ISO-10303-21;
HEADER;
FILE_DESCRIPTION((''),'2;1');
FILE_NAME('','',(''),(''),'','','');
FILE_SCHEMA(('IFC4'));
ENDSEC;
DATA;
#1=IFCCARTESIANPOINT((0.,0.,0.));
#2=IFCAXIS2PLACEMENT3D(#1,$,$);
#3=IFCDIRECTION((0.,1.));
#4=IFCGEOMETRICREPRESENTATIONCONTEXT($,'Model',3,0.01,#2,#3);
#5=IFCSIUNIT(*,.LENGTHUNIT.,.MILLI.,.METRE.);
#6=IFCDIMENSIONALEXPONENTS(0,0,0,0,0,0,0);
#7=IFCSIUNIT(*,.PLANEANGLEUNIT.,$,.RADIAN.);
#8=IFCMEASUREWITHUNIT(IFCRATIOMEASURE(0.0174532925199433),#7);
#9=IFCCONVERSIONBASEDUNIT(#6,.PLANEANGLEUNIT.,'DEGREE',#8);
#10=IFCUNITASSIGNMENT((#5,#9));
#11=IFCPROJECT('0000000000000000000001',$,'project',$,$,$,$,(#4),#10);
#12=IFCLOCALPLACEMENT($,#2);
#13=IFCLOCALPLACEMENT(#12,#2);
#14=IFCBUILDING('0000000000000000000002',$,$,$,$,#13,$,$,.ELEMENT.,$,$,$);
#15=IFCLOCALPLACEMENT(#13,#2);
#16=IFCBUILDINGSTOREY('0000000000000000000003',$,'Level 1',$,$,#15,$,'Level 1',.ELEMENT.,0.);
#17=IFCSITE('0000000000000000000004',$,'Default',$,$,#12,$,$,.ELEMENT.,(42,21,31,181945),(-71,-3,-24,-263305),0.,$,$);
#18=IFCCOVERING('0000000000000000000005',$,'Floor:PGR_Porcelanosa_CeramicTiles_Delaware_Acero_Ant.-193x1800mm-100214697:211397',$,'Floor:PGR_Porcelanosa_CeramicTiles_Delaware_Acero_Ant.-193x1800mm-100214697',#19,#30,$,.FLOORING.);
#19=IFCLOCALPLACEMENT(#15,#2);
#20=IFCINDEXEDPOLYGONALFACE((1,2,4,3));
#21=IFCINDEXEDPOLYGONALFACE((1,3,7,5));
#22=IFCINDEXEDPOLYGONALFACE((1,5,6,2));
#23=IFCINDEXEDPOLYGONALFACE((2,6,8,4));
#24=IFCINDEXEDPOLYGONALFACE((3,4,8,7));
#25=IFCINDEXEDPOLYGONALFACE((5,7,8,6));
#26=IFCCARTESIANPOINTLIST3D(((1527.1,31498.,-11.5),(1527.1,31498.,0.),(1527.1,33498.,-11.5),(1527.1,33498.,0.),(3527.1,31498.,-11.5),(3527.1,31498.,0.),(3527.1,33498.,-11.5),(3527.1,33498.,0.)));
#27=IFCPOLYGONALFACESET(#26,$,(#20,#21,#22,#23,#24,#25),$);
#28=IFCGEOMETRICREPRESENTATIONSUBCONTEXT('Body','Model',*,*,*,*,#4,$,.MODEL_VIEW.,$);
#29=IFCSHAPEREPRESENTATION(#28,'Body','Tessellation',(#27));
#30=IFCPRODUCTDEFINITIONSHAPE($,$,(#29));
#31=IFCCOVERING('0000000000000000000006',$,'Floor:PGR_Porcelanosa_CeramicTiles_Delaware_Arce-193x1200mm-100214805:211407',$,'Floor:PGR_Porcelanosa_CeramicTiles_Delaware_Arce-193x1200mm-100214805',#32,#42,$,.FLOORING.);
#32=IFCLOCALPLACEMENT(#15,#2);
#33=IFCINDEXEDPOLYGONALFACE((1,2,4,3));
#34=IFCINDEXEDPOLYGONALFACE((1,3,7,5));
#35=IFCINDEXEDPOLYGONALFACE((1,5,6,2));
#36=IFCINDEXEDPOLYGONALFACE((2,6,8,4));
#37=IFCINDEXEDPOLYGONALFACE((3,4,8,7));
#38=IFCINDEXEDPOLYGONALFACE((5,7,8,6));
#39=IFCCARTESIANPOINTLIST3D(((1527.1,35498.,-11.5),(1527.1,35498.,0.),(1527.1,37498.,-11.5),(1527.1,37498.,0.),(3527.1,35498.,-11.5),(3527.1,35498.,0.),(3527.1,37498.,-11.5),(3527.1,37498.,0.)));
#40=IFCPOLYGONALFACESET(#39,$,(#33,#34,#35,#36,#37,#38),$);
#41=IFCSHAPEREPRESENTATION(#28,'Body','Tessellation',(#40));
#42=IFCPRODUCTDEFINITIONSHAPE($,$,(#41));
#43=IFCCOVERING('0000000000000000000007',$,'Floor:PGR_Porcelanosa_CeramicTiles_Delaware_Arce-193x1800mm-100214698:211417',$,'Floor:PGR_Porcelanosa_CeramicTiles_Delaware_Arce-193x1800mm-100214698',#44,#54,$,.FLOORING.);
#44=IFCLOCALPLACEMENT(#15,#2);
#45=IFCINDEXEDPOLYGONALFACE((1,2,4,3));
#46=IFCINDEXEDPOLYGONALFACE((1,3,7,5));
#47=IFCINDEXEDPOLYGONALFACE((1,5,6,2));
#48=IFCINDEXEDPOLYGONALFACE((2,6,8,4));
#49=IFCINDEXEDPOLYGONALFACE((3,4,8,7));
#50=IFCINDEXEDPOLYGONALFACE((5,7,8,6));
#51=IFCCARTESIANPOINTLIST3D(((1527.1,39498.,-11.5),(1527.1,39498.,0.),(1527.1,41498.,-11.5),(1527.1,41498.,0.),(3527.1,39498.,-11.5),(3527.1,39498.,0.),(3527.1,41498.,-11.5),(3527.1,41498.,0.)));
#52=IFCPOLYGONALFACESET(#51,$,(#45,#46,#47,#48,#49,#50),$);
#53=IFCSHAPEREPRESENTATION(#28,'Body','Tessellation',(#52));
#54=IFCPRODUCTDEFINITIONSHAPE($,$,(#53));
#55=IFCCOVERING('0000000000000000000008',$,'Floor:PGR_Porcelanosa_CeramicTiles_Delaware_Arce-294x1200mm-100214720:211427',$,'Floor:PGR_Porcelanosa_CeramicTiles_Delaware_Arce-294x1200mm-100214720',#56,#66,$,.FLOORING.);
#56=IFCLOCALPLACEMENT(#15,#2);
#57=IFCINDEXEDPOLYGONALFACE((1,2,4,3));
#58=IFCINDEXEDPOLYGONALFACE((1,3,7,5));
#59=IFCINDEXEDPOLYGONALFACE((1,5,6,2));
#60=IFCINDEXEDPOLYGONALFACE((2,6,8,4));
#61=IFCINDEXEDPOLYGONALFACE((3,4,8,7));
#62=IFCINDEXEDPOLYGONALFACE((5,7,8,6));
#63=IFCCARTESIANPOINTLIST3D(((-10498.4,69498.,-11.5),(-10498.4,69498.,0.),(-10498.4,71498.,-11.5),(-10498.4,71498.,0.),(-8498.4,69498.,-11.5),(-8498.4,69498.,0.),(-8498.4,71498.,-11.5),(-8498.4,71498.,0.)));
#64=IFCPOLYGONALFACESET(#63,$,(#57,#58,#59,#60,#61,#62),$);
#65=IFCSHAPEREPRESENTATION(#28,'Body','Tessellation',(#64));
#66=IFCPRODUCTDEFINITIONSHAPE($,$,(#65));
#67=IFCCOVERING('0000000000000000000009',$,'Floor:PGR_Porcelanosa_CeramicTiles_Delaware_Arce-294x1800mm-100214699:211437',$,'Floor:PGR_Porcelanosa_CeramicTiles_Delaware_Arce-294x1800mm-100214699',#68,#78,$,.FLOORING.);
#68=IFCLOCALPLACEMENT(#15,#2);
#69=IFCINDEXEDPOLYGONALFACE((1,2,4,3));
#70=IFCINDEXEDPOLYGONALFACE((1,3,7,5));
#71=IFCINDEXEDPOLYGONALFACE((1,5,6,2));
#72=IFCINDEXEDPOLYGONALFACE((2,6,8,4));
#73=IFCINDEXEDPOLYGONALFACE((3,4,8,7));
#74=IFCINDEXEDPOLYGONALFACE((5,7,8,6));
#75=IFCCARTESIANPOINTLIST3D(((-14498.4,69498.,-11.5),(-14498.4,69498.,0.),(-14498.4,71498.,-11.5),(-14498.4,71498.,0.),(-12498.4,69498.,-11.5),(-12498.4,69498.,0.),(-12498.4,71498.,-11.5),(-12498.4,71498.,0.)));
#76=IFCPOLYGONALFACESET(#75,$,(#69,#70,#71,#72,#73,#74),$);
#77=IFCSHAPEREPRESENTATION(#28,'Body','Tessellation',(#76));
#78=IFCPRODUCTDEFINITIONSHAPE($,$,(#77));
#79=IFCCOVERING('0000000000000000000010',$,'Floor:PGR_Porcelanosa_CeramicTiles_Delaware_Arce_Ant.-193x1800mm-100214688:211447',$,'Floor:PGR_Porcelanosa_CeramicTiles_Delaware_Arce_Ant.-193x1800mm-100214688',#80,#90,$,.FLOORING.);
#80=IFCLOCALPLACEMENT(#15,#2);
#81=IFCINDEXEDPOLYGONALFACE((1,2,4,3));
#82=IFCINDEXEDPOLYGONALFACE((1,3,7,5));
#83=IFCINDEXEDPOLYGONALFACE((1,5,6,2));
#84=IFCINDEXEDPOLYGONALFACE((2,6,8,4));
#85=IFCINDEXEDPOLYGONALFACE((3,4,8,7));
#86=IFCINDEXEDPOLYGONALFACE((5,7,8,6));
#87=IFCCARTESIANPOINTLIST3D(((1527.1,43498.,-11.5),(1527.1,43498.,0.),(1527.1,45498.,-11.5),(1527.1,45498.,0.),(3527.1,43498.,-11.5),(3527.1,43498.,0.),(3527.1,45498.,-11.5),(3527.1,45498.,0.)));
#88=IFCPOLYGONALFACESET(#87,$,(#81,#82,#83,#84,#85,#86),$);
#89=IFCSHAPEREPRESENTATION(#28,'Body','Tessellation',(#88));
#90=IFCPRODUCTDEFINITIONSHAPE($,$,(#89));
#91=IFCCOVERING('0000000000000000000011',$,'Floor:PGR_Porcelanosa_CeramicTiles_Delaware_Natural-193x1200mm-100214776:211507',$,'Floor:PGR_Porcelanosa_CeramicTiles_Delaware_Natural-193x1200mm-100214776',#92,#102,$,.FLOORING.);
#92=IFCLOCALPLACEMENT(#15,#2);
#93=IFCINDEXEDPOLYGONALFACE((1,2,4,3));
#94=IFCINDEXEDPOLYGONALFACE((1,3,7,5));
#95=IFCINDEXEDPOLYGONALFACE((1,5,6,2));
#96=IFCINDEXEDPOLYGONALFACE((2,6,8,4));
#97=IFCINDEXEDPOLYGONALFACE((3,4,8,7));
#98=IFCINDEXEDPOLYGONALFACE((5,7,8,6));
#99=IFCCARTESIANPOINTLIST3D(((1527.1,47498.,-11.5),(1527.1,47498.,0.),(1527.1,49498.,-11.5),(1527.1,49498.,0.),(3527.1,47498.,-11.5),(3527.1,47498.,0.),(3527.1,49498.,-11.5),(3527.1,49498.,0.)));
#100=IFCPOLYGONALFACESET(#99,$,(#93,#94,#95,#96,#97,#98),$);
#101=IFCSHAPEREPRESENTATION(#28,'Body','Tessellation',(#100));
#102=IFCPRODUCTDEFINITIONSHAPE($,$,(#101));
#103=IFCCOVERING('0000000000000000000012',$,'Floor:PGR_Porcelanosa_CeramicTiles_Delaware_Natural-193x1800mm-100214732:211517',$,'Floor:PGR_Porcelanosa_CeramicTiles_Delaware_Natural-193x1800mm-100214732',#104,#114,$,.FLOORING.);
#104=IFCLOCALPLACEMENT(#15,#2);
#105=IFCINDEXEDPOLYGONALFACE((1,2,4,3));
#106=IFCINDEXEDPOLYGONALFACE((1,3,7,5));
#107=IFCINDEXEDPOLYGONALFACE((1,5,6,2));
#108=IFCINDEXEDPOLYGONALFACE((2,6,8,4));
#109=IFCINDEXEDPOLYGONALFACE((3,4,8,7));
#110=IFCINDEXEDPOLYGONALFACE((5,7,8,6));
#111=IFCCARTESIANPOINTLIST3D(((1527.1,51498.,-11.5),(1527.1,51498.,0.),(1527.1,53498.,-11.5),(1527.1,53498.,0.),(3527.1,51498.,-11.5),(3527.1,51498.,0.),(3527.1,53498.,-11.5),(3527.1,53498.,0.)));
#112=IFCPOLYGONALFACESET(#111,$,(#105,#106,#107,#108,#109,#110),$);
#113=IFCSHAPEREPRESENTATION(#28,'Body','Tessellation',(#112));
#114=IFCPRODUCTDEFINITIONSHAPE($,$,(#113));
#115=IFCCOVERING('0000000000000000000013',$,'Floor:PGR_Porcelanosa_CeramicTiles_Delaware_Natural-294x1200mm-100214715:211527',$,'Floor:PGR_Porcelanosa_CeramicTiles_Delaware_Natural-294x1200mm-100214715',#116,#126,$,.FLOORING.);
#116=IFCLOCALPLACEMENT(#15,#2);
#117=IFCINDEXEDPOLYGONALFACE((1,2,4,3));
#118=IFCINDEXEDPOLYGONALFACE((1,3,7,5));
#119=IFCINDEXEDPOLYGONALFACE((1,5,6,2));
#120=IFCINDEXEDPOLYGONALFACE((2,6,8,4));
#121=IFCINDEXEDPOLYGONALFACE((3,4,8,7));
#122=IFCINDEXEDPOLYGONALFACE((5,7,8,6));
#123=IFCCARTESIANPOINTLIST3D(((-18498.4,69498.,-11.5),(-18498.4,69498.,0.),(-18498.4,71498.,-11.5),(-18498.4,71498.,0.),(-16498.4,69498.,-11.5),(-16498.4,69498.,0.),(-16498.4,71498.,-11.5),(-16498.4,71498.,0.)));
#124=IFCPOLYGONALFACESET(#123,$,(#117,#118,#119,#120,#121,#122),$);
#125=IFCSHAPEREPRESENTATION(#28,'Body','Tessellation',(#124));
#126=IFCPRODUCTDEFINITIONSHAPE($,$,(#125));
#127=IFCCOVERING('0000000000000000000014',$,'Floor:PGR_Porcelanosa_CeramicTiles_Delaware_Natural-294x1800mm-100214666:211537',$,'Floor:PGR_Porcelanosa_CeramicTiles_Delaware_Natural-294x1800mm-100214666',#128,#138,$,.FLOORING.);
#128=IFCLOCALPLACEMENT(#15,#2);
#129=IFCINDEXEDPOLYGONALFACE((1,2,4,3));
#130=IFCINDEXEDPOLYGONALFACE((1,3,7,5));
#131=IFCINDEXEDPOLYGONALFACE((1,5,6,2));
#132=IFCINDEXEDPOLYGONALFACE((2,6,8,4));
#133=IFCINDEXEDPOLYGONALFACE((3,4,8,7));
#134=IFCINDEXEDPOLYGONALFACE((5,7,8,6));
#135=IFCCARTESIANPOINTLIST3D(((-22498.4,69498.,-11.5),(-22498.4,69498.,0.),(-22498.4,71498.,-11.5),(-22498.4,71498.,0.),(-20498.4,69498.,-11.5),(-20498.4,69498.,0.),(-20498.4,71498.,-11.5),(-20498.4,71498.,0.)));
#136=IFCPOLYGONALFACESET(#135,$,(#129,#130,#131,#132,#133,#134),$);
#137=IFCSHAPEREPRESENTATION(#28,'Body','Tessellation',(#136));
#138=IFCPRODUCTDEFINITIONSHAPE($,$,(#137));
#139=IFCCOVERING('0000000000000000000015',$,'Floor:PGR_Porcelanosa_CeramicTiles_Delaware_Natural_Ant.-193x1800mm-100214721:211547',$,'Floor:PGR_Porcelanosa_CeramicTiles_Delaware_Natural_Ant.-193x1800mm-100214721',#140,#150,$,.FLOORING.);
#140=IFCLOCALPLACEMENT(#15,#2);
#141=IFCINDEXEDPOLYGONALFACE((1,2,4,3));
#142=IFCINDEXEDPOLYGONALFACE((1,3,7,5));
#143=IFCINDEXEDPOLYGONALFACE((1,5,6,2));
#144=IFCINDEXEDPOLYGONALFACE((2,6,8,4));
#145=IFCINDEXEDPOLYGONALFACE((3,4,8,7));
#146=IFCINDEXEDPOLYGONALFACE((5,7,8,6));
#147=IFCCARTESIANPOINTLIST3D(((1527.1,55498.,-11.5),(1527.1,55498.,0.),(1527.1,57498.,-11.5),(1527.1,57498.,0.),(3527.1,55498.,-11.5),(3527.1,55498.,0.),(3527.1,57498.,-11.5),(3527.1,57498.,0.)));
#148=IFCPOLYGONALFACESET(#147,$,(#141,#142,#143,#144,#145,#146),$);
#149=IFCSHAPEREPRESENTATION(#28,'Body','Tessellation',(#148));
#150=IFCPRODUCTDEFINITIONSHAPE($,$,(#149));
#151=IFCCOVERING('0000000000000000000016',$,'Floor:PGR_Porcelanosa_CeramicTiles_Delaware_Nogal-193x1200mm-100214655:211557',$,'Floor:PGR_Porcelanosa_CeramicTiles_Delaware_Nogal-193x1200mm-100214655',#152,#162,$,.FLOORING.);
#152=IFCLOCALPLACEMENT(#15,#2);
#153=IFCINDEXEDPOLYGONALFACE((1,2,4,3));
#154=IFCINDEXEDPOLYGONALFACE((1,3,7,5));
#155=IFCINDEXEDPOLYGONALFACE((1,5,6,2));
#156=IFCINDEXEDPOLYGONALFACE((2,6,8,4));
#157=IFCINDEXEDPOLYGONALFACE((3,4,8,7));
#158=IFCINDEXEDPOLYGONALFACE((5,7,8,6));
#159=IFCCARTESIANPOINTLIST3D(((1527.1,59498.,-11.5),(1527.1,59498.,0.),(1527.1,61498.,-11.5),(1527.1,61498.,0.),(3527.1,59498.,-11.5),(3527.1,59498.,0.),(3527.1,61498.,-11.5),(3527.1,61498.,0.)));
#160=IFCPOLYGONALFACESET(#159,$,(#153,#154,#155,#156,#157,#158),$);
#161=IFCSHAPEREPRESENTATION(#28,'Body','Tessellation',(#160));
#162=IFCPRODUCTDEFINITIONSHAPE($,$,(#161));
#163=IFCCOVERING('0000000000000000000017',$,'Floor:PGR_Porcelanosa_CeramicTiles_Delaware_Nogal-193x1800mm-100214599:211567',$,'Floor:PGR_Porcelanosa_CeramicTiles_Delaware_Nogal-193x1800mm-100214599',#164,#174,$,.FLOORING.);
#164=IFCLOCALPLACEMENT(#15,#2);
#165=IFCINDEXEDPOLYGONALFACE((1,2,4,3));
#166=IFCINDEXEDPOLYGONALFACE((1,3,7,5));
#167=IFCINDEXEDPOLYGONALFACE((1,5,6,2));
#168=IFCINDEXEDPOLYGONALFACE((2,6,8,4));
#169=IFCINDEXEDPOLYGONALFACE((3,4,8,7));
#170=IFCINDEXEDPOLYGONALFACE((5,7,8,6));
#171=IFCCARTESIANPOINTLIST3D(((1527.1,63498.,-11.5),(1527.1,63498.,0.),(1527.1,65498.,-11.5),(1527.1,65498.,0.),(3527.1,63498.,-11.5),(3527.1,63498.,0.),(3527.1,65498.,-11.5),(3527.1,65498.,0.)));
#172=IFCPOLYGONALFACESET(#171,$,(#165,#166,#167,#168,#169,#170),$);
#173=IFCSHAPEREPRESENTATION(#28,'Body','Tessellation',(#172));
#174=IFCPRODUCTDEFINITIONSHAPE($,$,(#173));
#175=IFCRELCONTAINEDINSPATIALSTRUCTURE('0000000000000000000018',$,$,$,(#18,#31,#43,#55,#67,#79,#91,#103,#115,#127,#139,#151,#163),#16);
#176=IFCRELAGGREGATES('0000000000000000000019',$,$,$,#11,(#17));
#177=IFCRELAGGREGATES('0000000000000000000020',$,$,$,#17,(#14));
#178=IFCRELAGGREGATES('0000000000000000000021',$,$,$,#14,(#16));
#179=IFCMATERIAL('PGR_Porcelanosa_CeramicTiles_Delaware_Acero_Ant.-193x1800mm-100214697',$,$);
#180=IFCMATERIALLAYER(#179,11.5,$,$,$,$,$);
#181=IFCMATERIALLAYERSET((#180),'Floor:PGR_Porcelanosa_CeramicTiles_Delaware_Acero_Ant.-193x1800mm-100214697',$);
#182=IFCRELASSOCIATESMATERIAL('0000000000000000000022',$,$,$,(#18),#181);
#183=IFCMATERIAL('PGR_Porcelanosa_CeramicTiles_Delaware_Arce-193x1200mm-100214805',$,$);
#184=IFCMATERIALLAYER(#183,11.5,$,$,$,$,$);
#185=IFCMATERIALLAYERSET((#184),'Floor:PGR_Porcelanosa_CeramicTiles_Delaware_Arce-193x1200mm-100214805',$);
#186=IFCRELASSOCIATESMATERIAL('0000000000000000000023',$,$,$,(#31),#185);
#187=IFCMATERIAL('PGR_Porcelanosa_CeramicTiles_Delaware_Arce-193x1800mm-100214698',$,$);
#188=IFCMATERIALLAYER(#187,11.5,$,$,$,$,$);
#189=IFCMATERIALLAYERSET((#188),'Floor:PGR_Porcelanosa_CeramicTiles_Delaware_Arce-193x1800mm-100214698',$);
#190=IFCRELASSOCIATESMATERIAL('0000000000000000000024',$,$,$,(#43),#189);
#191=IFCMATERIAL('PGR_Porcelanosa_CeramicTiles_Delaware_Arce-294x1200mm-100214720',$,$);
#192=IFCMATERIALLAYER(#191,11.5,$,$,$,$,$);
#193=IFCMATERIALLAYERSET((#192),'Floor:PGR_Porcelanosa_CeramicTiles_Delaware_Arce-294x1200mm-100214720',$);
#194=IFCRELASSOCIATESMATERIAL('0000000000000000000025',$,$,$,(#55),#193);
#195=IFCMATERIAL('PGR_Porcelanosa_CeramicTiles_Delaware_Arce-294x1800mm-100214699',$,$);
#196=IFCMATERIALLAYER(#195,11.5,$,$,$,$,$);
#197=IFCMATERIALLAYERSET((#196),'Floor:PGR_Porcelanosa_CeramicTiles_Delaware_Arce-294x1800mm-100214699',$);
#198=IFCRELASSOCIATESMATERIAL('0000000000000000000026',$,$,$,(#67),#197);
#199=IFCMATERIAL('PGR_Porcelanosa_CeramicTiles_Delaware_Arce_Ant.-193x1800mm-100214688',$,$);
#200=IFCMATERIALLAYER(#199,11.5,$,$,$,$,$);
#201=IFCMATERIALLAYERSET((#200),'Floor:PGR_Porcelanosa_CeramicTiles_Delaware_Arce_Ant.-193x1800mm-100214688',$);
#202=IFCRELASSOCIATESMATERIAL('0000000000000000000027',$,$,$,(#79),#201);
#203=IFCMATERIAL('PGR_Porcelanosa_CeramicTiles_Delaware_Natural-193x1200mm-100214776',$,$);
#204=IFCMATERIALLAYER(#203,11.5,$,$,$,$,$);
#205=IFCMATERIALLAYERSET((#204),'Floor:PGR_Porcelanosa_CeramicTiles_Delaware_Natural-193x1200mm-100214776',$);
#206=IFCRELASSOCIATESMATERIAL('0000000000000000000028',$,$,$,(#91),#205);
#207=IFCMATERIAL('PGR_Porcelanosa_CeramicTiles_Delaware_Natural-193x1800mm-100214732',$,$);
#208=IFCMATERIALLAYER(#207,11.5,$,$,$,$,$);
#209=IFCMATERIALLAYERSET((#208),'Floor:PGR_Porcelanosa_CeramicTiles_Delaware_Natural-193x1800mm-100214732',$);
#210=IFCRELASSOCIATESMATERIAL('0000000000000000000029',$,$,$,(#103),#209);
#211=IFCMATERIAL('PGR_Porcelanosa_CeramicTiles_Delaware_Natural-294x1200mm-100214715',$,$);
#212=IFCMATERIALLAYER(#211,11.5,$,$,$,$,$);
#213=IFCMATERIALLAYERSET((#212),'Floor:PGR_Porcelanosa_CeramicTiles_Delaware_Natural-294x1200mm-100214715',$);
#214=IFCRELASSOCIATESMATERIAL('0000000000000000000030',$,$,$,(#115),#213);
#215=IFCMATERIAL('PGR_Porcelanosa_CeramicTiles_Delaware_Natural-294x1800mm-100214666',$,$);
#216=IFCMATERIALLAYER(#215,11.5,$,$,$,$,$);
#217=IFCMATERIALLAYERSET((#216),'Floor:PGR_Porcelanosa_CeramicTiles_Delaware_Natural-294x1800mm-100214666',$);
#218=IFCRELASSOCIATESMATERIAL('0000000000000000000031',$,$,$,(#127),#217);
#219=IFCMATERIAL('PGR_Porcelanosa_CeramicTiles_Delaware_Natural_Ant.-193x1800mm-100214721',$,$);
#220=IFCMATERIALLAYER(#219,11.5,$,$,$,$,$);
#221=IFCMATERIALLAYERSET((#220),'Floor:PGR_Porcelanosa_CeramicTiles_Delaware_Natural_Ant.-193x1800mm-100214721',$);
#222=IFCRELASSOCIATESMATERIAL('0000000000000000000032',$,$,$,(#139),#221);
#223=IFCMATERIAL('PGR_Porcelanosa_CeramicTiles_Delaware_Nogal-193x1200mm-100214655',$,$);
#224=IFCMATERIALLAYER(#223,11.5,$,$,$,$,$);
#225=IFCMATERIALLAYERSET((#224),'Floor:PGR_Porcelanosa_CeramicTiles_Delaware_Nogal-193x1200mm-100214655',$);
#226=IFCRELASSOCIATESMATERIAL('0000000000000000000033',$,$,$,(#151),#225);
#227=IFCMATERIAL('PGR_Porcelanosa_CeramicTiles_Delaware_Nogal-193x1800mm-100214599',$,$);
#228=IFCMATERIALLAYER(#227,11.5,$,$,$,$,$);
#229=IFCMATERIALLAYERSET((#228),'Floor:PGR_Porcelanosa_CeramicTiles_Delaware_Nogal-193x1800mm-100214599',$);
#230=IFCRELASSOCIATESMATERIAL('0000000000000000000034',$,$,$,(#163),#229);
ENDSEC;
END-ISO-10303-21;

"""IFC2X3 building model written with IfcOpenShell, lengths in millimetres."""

from ifc_helpers import new_model, entity, si_unit, converted_unit, direction, frame, frame_2d, origin, origin_2d_with_axis, place, context, subcontext, project, spatial, rectangle, extrude, material, layer, layer_set, layer_usage, element, save


model = new_model("IFC2X3")

# Units and contexts
model_context = context("Model", 3, precision=0.01, world=origin(), true_north=direction((0.0, 1.0)))
body_context = subcontext(model_context, "Body", "Model", "MODEL_VIEW")
ifc_project = project(units=[si_unit("LENGTHUNIT", "METRE", prefix="MILLI"), converted_unit("PLANEANGLEUNIT", "DEGREE", entity("IfcRatioMeasure", 0.0174532925199433), si_unit("PLANEANGLEUNIT", "RADIAN"), dimensions=[0, 0, 0, 0, 0, 0, 0])], contexts=[model_context])

# Site, building, storey
site_placement = place(None, origin())
site = spatial("IfcSite", under=ifc_project, at=site_placement, Name="Default", CompositionType="ELEMENT", RefLatitude=(42, 21, 31, 181945), RefLongitude=(-71, -3, -24, -263305), RefElevation=0.0)
building_placement = place(site_placement, origin())
building = spatial("IfcBuilding", under=site, at=building_placement, CompositionType="ELEMENT")
storey_placement = place(building_placement, origin())
storey = spatial("IfcBuildingStorey", under=building, at=storey_placement, Name="Level 1", LongName="Level 1", CompositionType="ELEMENT", Elevation=0.0)

# Shared definitions
ifc_material_1 = material(Name="PGR_Porcelanosa_CeramicTiles_Delaware_Acero_Ant.-193x1800mm-100214697")
ifc_material_2 = material(Name="PGR_Porcelanosa_CeramicTiles_Delaware_Arce-193x1200mm-100214805")
ifc_material_3 = material(Name="PGR_Porcelanosa_CeramicTiles_Delaware_Arce-193x1800mm-100214698")
ifc_material_4 = material(Name="PGR_Porcelanosa_CeramicTiles_Delaware_Arce-294x1200mm-100214720")
ifc_material_5 = material(Name="PGR_Porcelanosa_CeramicTiles_Delaware_Arce-294x1800mm-100214699")
ifc_material_6 = material(Name="PGR_Porcelanosa_CeramicTiles_Delaware_Arce_Ant.-193x1800mm-100214688")
ifc_material_7 = material(Name="PGR_Porcelanosa_CeramicTiles_Delaware_Natural-193x1200mm-100214776")
ifc_material_8 = material(Name="PGR_Porcelanosa_CeramicTiles_Delaware_Natural-193x1800mm-100214732")
ifc_material_9 = material(Name="PGR_Porcelanosa_CeramicTiles_Delaware_Natural-294x1200mm-100214715")
ifc_material_10 = material(Name="PGR_Porcelanosa_CeramicTiles_Delaware_Natural-294x1800mm-100214666")
ifc_material_11 = material(Name="PGR_Porcelanosa_CeramicTiles_Delaware_Natural_Ant.-193x1800mm-100214721")
ifc_material_12 = material(Name="PGR_Porcelanosa_CeramicTiles_Delaware_Nogal-193x1200mm-100214655")
ifc_material_13 = material(Name="PGR_Porcelanosa_CeramicTiles_Delaware_Nogal-193x1800mm-100214599")

# Coverings
ifc_layer_1 = layer(ifc_material_1, 11.5)
ifc_layer_set_1 = layer_set([ifc_layer_1], Name="Floor:PGR_Porcelanosa_CeramicTiles_Delaware_Acero_Ant.-193x1800mm-100214697")
ifc_layer_usage_1 = layer_usage(ifc_layer_set_1, "AXIS3", "POSITIVE", 0.0)
covering_1_placement = place(storey_placement, origin())
element("IfcCovering", 1, at=covering_1_placement, inside=storey, material=ifc_layer_usage_1, Name="Floor:PGR_Porcelanosa_CeramicTiles_Delaware_Acero_Ant.-193x1800mm-100214697:211397", ObjectType="Floor:PGR_Porcelanosa_CeramicTiles_Delaware_Acero_Ant.-193x1800mm-100214697", PredefinedType="FLOORING", context=body_context, shape_type="SweptSolid", body=[
    extrude(rectangle(XDim=2000.0, YDim=2000.0, at=frame_2d((0.0, 0.0), x_axis=(1.0, 0.0))), frame((2527.1, 32498.0, 0.0), z_axis=(0.0, 0.0, -1.0), x_axis=(0.0, 1.0, 0.0)), (0.0, 0.0, 1.0), 11.5),
])
ifc_layer_2 = layer(ifc_material_2, 11.5)
ifc_layer_set_2 = layer_set([ifc_layer_2], Name="Floor:PGR_Porcelanosa_CeramicTiles_Delaware_Arce-193x1200mm-100214805")
ifc_layer_usage_2 = layer_usage(ifc_layer_set_2, "AXIS3", "POSITIVE", 0.0)
covering_2_placement = place(storey_placement, origin())
element("IfcCovering", 2, at=covering_2_placement, inside=storey, material=ifc_layer_usage_2, Name="Floor:PGR_Porcelanosa_CeramicTiles_Delaware_Arce-193x1200mm-100214805:211407", ObjectType="Floor:PGR_Porcelanosa_CeramicTiles_Delaware_Arce-193x1200mm-100214805", PredefinedType="FLOORING", context=body_context, shape_type="SweptSolid", body=[
    extrude(rectangle(XDim=2000.0, YDim=2000.0, at=frame_2d((0.0, 0.0), x_axis=(1.0, 0.0))), frame((2527.1, 36498.0, 0.0), z_axis=(0.0, 0.0, -1.0), x_axis=(0.0, 1.0, 0.0)), (0.0, 0.0, 1.0), 11.5),
])
ifc_layer_3 = layer(ifc_material_3, 11.5)
ifc_layer_set_3 = layer_set([ifc_layer_3], Name="Floor:PGR_Porcelanosa_CeramicTiles_Delaware_Arce-193x1800mm-100214698")
ifc_layer_usage_3 = layer_usage(ifc_layer_set_3, "AXIS3", "POSITIVE", 0.0)
covering_3_placement = place(storey_placement, origin())
element("IfcCovering", 3, at=covering_3_placement, inside=storey, material=ifc_layer_usage_3, Name="Floor:PGR_Porcelanosa_CeramicTiles_Delaware_Arce-193x1800mm-100214698:211417", ObjectType="Floor:PGR_Porcelanosa_CeramicTiles_Delaware_Arce-193x1800mm-100214698", PredefinedType="FLOORING", context=body_context, shape_type="SweptSolid", body=[
    extrude(rectangle(XDim=2000.0, YDim=2000.0, at=frame_2d((0.0, 0.0), x_axis=(1.0, 0.0))), frame((2527.1, 40498.0, 0.0), z_axis=(0.0, 0.0, -1.0), x_axis=(0.0, 1.0, 0.0)), (0.0, 0.0, 1.0), 11.5),
])
ifc_layer_4 = layer(ifc_material_4, 11.5)
ifc_layer_set_4 = layer_set([ifc_layer_4], Name="Floor:PGR_Porcelanosa_CeramicTiles_Delaware_Arce-294x1200mm-100214720")
ifc_layer_usage_4 = layer_usage(ifc_layer_set_4, "AXIS3", "POSITIVE", 0.0)
covering_4_placement = place(storey_placement, origin())
element("IfcCovering", 4, at=covering_4_placement, inside=storey, material=ifc_layer_usage_4, Name="Floor:PGR_Porcelanosa_CeramicTiles_Delaware_Arce-294x1200mm-100214720:211427", ObjectType="Floor:PGR_Porcelanosa_CeramicTiles_Delaware_Arce-294x1200mm-100214720", PredefinedType="FLOORING", context=body_context, shape_type="SweptSolid", body=[
    extrude(rectangle(XDim=2000.0, YDim=2000.0, at=frame_2d((0.0, 0.0), x_axis=(1.0, 0.0))), frame((-9498.4, 70498.0, 0.0), z_axis=(0.0, 0.0, -1.0), x_axis=(0.0, 1.0, 0.0)), (0.0, 0.0, 1.0), 11.5),
])
ifc_layer_5 = layer(ifc_material_5, 11.5)
ifc_layer_set_5 = layer_set([ifc_layer_5], Name="Floor:PGR_Porcelanosa_CeramicTiles_Delaware_Arce-294x1800mm-100214699")
ifc_layer_usage_5 = layer_usage(ifc_layer_set_5, "AXIS3", "POSITIVE", 0.0)
covering_5_placement = place(storey_placement, origin())
element("IfcCovering", 5, at=covering_5_placement, inside=storey, material=ifc_layer_usage_5, Name="Floor:PGR_Porcelanosa_CeramicTiles_Delaware_Arce-294x1800mm-100214699:211437", ObjectType="Floor:PGR_Porcelanosa_CeramicTiles_Delaware_Arce-294x1800mm-100214699", PredefinedType="FLOORING", context=body_context, shape_type="SweptSolid", body=[
    extrude(rectangle(XDim=2000.0, YDim=2000.0, at=origin_2d_with_axis()), frame((-13498.4, 70498.0, 0.0), z_axis=(0.0, 0.0, -1.0), x_axis=(0.0, 1.0, 0.0)), (0.0, 0.0, 1.0), 11.5),
])
ifc_layer_6 = layer(ifc_material_6, 11.5)
ifc_layer_set_6 = layer_set([ifc_layer_6], Name="Floor:PGR_Porcelanosa_CeramicTiles_Delaware_Arce_Ant.-193x1800mm-100214688")
ifc_layer_usage_6 = layer_usage(ifc_layer_set_6, "AXIS3", "POSITIVE", 0.0)
covering_6_placement = place(storey_placement, origin())
element("IfcCovering", 6, at=covering_6_placement, inside=storey, material=ifc_layer_usage_6, Name="Floor:PGR_Porcelanosa_CeramicTiles_Delaware_Arce_Ant.-193x1800mm-100214688:211447", ObjectType="Floor:PGR_Porcelanosa_CeramicTiles_Delaware_Arce_Ant.-193x1800mm-100214688", PredefinedType="FLOORING", context=body_context, shape_type="SweptSolid", body=[
    extrude(rectangle(XDim=2000.0, YDim=2000.0, at=frame_2d((0.0, 0.0), x_axis=(1.0, 0.0))), frame((2527.1, 44498.0, 0.0), z_axis=(0.0, 0.0, -1.0), x_axis=(0.0, 1.0, 0.0)), (0.0, 0.0, 1.0), 11.5),
])
ifc_layer_7 = layer(ifc_material_7, 11.5)
ifc_layer_set_7 = layer_set([ifc_layer_7], Name="Floor:PGR_Porcelanosa_CeramicTiles_Delaware_Natural-193x1200mm-100214776")
ifc_layer_usage_7 = layer_usage(ifc_layer_set_7, "AXIS3", "POSITIVE", 0.0)
covering_7_placement = place(storey_placement, origin())
element("IfcCovering", 7, at=covering_7_placement, inside=storey, material=ifc_layer_usage_7, Name="Floor:PGR_Porcelanosa_CeramicTiles_Delaware_Natural-193x1200mm-100214776:211507", ObjectType="Floor:PGR_Porcelanosa_CeramicTiles_Delaware_Natural-193x1200mm-100214776", PredefinedType="FLOORING", context=body_context, shape_type="SweptSolid", body=[
    extrude(rectangle(XDim=2000.0, YDim=2000.0, at=frame_2d((0.0, 0.0), x_axis=(1.0, 0.0))), frame((2527.1, 48498.0, 0.0), z_axis=(0.0, 0.0, -1.0), x_axis=(0.0, 1.0, 0.0)), (0.0, 0.0, 1.0), 11.5),
])
ifc_layer_8 = layer(ifc_material_8, 11.5)
ifc_layer_set_8 = layer_set([ifc_layer_8], Name="Floor:PGR_Porcelanosa_CeramicTiles_Delaware_Natural-193x1800mm-100214732")
ifc_layer_usage_8 = layer_usage(ifc_layer_set_8, "AXIS3", "POSITIVE", 0.0)
covering_8_placement = place(storey_placement, origin())
element("IfcCovering", 8, at=covering_8_placement, inside=storey, material=ifc_layer_usage_8, Name="Floor:PGR_Porcelanosa_CeramicTiles_Delaware_Natural-193x1800mm-100214732:211517", ObjectType="Floor:PGR_Porcelanosa_CeramicTiles_Delaware_Natural-193x1800mm-100214732", PredefinedType="FLOORING", context=body_context, shape_type="SweptSolid", body=[
    extrude(rectangle(XDim=2000.0, YDim=2000.0, at=frame_2d((0.0, 0.0), x_axis=(1.0, 0.0))), frame((2527.1, 52498.0, 0.0), z_axis=(0.0, 0.0, -1.0), x_axis=(0.0, 1.0, 0.0)), (0.0, 0.0, 1.0), 11.5),
])
ifc_layer_9 = layer(ifc_material_9, 11.5)
ifc_layer_set_9 = layer_set([ifc_layer_9], Name="Floor:PGR_Porcelanosa_CeramicTiles_Delaware_Natural-294x1200mm-100214715")
ifc_layer_usage_9 = layer_usage(ifc_layer_set_9, "AXIS3", "POSITIVE", 0.0)
covering_9_placement = place(storey_placement, origin())
element("IfcCovering", 9, at=covering_9_placement, inside=storey, material=ifc_layer_usage_9, Name="Floor:PGR_Porcelanosa_CeramicTiles_Delaware_Natural-294x1200mm-100214715:211527", ObjectType="Floor:PGR_Porcelanosa_CeramicTiles_Delaware_Natural-294x1200mm-100214715", PredefinedType="FLOORING", context=body_context, shape_type="SweptSolid", body=[
    extrude(rectangle(XDim=2000.0, YDim=2000.0, at=frame_2d((0.0, 0.0), x_axis=(1.0, 0.0))), frame((-17498.4, 70498.0, 0.0), z_axis=(0.0, 0.0, -1.0), x_axis=(0.0, 1.0, 0.0)), (0.0, 0.0, 1.0), 11.5),
])
ifc_layer_10 = layer(ifc_material_10, 11.5)
ifc_layer_set_10 = layer_set([ifc_layer_10], Name="Floor:PGR_Porcelanosa_CeramicTiles_Delaware_Natural-294x1800mm-100214666")
ifc_layer_usage_10 = layer_usage(ifc_layer_set_10, "AXIS3", "POSITIVE", 0.0)
covering_10_placement = place(storey_placement, origin())
element("IfcCovering", 10, at=covering_10_placement, inside=storey, material=ifc_layer_usage_10, Name="Floor:PGR_Porcelanosa_CeramicTiles_Delaware_Natural-294x1800mm-100214666:211537", ObjectType="Floor:PGR_Porcelanosa_CeramicTiles_Delaware_Natural-294x1800mm-100214666", PredefinedType="FLOORING", context=body_context, shape_type="SweptSolid", body=[
    extrude(rectangle(XDim=2000.0, YDim=2000.0, at=frame_2d((0.0, 0.0), x_axis=(1.0, 0.0))), frame((-21498.4, 70498.0, 0.0), z_axis=(0.0, 0.0, -1.0), x_axis=(0.0, 1.0, 0.0)), (0.0, 0.0, 1.0), 11.5),
])
ifc_layer_11 = layer(ifc_material_11, 11.5)
ifc_layer_set_11 = layer_set([ifc_layer_11], Name="Floor:PGR_Porcelanosa_CeramicTiles_Delaware_Natural_Ant.-193x1800mm-100214721")
ifc_layer_usage_11 = layer_usage(ifc_layer_set_11, "AXIS3", "POSITIVE", 0.0)
covering_11_placement = place(storey_placement, origin())
element("IfcCovering", 11, at=covering_11_placement, inside=storey, material=ifc_layer_usage_11, Name="Floor:PGR_Porcelanosa_CeramicTiles_Delaware_Natural_Ant.-193x1800mm-100214721:211547", ObjectType="Floor:PGR_Porcelanosa_CeramicTiles_Delaware_Natural_Ant.-193x1800mm-100214721", PredefinedType="FLOORING", context=body_context, shape_type="SweptSolid", body=[
    extrude(rectangle(XDim=2000.0, YDim=2000.0, at=frame_2d((0.0, 0.0), x_axis=(1.0, 0.0))), frame((2527.1, 56498.0, 0.0), z_axis=(0.0, 0.0, -1.0), x_axis=(0.0, 1.0, 0.0)), (0.0, 0.0, 1.0), 11.5),
])
ifc_layer_12 = layer(ifc_material_12, 11.5)
ifc_layer_set_12 = layer_set([ifc_layer_12], Name="Floor:PGR_Porcelanosa_CeramicTiles_Delaware_Nogal-193x1200mm-100214655")
ifc_layer_usage_12 = layer_usage(ifc_layer_set_12, "AXIS3", "POSITIVE", 0.0)
covering_12_placement = place(storey_placement, origin())
element("IfcCovering", 12, at=covering_12_placement, inside=storey, material=ifc_layer_usage_12, Name="Floor:PGR_Porcelanosa_CeramicTiles_Delaware_Nogal-193x1200mm-100214655:211557", ObjectType="Floor:PGR_Porcelanosa_CeramicTiles_Delaware_Nogal-193x1200mm-100214655", PredefinedType="FLOORING", context=body_context, shape_type="SweptSolid", body=[
    extrude(rectangle(XDim=2000.0, YDim=2000.0, at=frame_2d((0.0, 0.0), x_axis=(1.0, 0.0))), frame((2527.1, 60498.0, 0.0), z_axis=(0.0, 0.0, -1.0), x_axis=(0.0, 1.0, 0.0)), (0.0, 0.0, 1.0), 11.5),
])
ifc_layer_13 = layer(ifc_material_13, 11.5)
ifc_layer_set_13 = layer_set([ifc_layer_13], Name="Floor:PGR_Porcelanosa_CeramicTiles_Delaware_Nogal-193x1800mm-100214599")
ifc_layer_usage_13 = layer_usage(ifc_layer_set_13, "AXIS3", "POSITIVE", 0.0)
covering_13_placement = place(storey_placement, origin())
element("IfcCovering", 13, at=covering_13_placement, inside=storey, material=ifc_layer_usage_13, Name="Floor:PGR_Porcelanosa_CeramicTiles_Delaware_Nogal-193x1800mm-100214599:211567", ObjectType="Floor:PGR_Porcelanosa_CeramicTiles_Delaware_Nogal-193x1800mm-100214599", PredefinedType="FLOORING", context=body_context, shape_type="SweptSolid", body=[
    extrude(rectangle(XDim=2000.0, YDim=2000.0, at=frame_2d((0.0, 0.0), x_axis=(1.0, 0.0))), frame((2527.1, 64498.0, 0.0), z_axis=(0.0, 0.0, -1.0), x_axis=(0.0, 1.0, 0.0)), (0.0, 0.0, 1.0), 11.5),
])

save(model, "model.ifc")
